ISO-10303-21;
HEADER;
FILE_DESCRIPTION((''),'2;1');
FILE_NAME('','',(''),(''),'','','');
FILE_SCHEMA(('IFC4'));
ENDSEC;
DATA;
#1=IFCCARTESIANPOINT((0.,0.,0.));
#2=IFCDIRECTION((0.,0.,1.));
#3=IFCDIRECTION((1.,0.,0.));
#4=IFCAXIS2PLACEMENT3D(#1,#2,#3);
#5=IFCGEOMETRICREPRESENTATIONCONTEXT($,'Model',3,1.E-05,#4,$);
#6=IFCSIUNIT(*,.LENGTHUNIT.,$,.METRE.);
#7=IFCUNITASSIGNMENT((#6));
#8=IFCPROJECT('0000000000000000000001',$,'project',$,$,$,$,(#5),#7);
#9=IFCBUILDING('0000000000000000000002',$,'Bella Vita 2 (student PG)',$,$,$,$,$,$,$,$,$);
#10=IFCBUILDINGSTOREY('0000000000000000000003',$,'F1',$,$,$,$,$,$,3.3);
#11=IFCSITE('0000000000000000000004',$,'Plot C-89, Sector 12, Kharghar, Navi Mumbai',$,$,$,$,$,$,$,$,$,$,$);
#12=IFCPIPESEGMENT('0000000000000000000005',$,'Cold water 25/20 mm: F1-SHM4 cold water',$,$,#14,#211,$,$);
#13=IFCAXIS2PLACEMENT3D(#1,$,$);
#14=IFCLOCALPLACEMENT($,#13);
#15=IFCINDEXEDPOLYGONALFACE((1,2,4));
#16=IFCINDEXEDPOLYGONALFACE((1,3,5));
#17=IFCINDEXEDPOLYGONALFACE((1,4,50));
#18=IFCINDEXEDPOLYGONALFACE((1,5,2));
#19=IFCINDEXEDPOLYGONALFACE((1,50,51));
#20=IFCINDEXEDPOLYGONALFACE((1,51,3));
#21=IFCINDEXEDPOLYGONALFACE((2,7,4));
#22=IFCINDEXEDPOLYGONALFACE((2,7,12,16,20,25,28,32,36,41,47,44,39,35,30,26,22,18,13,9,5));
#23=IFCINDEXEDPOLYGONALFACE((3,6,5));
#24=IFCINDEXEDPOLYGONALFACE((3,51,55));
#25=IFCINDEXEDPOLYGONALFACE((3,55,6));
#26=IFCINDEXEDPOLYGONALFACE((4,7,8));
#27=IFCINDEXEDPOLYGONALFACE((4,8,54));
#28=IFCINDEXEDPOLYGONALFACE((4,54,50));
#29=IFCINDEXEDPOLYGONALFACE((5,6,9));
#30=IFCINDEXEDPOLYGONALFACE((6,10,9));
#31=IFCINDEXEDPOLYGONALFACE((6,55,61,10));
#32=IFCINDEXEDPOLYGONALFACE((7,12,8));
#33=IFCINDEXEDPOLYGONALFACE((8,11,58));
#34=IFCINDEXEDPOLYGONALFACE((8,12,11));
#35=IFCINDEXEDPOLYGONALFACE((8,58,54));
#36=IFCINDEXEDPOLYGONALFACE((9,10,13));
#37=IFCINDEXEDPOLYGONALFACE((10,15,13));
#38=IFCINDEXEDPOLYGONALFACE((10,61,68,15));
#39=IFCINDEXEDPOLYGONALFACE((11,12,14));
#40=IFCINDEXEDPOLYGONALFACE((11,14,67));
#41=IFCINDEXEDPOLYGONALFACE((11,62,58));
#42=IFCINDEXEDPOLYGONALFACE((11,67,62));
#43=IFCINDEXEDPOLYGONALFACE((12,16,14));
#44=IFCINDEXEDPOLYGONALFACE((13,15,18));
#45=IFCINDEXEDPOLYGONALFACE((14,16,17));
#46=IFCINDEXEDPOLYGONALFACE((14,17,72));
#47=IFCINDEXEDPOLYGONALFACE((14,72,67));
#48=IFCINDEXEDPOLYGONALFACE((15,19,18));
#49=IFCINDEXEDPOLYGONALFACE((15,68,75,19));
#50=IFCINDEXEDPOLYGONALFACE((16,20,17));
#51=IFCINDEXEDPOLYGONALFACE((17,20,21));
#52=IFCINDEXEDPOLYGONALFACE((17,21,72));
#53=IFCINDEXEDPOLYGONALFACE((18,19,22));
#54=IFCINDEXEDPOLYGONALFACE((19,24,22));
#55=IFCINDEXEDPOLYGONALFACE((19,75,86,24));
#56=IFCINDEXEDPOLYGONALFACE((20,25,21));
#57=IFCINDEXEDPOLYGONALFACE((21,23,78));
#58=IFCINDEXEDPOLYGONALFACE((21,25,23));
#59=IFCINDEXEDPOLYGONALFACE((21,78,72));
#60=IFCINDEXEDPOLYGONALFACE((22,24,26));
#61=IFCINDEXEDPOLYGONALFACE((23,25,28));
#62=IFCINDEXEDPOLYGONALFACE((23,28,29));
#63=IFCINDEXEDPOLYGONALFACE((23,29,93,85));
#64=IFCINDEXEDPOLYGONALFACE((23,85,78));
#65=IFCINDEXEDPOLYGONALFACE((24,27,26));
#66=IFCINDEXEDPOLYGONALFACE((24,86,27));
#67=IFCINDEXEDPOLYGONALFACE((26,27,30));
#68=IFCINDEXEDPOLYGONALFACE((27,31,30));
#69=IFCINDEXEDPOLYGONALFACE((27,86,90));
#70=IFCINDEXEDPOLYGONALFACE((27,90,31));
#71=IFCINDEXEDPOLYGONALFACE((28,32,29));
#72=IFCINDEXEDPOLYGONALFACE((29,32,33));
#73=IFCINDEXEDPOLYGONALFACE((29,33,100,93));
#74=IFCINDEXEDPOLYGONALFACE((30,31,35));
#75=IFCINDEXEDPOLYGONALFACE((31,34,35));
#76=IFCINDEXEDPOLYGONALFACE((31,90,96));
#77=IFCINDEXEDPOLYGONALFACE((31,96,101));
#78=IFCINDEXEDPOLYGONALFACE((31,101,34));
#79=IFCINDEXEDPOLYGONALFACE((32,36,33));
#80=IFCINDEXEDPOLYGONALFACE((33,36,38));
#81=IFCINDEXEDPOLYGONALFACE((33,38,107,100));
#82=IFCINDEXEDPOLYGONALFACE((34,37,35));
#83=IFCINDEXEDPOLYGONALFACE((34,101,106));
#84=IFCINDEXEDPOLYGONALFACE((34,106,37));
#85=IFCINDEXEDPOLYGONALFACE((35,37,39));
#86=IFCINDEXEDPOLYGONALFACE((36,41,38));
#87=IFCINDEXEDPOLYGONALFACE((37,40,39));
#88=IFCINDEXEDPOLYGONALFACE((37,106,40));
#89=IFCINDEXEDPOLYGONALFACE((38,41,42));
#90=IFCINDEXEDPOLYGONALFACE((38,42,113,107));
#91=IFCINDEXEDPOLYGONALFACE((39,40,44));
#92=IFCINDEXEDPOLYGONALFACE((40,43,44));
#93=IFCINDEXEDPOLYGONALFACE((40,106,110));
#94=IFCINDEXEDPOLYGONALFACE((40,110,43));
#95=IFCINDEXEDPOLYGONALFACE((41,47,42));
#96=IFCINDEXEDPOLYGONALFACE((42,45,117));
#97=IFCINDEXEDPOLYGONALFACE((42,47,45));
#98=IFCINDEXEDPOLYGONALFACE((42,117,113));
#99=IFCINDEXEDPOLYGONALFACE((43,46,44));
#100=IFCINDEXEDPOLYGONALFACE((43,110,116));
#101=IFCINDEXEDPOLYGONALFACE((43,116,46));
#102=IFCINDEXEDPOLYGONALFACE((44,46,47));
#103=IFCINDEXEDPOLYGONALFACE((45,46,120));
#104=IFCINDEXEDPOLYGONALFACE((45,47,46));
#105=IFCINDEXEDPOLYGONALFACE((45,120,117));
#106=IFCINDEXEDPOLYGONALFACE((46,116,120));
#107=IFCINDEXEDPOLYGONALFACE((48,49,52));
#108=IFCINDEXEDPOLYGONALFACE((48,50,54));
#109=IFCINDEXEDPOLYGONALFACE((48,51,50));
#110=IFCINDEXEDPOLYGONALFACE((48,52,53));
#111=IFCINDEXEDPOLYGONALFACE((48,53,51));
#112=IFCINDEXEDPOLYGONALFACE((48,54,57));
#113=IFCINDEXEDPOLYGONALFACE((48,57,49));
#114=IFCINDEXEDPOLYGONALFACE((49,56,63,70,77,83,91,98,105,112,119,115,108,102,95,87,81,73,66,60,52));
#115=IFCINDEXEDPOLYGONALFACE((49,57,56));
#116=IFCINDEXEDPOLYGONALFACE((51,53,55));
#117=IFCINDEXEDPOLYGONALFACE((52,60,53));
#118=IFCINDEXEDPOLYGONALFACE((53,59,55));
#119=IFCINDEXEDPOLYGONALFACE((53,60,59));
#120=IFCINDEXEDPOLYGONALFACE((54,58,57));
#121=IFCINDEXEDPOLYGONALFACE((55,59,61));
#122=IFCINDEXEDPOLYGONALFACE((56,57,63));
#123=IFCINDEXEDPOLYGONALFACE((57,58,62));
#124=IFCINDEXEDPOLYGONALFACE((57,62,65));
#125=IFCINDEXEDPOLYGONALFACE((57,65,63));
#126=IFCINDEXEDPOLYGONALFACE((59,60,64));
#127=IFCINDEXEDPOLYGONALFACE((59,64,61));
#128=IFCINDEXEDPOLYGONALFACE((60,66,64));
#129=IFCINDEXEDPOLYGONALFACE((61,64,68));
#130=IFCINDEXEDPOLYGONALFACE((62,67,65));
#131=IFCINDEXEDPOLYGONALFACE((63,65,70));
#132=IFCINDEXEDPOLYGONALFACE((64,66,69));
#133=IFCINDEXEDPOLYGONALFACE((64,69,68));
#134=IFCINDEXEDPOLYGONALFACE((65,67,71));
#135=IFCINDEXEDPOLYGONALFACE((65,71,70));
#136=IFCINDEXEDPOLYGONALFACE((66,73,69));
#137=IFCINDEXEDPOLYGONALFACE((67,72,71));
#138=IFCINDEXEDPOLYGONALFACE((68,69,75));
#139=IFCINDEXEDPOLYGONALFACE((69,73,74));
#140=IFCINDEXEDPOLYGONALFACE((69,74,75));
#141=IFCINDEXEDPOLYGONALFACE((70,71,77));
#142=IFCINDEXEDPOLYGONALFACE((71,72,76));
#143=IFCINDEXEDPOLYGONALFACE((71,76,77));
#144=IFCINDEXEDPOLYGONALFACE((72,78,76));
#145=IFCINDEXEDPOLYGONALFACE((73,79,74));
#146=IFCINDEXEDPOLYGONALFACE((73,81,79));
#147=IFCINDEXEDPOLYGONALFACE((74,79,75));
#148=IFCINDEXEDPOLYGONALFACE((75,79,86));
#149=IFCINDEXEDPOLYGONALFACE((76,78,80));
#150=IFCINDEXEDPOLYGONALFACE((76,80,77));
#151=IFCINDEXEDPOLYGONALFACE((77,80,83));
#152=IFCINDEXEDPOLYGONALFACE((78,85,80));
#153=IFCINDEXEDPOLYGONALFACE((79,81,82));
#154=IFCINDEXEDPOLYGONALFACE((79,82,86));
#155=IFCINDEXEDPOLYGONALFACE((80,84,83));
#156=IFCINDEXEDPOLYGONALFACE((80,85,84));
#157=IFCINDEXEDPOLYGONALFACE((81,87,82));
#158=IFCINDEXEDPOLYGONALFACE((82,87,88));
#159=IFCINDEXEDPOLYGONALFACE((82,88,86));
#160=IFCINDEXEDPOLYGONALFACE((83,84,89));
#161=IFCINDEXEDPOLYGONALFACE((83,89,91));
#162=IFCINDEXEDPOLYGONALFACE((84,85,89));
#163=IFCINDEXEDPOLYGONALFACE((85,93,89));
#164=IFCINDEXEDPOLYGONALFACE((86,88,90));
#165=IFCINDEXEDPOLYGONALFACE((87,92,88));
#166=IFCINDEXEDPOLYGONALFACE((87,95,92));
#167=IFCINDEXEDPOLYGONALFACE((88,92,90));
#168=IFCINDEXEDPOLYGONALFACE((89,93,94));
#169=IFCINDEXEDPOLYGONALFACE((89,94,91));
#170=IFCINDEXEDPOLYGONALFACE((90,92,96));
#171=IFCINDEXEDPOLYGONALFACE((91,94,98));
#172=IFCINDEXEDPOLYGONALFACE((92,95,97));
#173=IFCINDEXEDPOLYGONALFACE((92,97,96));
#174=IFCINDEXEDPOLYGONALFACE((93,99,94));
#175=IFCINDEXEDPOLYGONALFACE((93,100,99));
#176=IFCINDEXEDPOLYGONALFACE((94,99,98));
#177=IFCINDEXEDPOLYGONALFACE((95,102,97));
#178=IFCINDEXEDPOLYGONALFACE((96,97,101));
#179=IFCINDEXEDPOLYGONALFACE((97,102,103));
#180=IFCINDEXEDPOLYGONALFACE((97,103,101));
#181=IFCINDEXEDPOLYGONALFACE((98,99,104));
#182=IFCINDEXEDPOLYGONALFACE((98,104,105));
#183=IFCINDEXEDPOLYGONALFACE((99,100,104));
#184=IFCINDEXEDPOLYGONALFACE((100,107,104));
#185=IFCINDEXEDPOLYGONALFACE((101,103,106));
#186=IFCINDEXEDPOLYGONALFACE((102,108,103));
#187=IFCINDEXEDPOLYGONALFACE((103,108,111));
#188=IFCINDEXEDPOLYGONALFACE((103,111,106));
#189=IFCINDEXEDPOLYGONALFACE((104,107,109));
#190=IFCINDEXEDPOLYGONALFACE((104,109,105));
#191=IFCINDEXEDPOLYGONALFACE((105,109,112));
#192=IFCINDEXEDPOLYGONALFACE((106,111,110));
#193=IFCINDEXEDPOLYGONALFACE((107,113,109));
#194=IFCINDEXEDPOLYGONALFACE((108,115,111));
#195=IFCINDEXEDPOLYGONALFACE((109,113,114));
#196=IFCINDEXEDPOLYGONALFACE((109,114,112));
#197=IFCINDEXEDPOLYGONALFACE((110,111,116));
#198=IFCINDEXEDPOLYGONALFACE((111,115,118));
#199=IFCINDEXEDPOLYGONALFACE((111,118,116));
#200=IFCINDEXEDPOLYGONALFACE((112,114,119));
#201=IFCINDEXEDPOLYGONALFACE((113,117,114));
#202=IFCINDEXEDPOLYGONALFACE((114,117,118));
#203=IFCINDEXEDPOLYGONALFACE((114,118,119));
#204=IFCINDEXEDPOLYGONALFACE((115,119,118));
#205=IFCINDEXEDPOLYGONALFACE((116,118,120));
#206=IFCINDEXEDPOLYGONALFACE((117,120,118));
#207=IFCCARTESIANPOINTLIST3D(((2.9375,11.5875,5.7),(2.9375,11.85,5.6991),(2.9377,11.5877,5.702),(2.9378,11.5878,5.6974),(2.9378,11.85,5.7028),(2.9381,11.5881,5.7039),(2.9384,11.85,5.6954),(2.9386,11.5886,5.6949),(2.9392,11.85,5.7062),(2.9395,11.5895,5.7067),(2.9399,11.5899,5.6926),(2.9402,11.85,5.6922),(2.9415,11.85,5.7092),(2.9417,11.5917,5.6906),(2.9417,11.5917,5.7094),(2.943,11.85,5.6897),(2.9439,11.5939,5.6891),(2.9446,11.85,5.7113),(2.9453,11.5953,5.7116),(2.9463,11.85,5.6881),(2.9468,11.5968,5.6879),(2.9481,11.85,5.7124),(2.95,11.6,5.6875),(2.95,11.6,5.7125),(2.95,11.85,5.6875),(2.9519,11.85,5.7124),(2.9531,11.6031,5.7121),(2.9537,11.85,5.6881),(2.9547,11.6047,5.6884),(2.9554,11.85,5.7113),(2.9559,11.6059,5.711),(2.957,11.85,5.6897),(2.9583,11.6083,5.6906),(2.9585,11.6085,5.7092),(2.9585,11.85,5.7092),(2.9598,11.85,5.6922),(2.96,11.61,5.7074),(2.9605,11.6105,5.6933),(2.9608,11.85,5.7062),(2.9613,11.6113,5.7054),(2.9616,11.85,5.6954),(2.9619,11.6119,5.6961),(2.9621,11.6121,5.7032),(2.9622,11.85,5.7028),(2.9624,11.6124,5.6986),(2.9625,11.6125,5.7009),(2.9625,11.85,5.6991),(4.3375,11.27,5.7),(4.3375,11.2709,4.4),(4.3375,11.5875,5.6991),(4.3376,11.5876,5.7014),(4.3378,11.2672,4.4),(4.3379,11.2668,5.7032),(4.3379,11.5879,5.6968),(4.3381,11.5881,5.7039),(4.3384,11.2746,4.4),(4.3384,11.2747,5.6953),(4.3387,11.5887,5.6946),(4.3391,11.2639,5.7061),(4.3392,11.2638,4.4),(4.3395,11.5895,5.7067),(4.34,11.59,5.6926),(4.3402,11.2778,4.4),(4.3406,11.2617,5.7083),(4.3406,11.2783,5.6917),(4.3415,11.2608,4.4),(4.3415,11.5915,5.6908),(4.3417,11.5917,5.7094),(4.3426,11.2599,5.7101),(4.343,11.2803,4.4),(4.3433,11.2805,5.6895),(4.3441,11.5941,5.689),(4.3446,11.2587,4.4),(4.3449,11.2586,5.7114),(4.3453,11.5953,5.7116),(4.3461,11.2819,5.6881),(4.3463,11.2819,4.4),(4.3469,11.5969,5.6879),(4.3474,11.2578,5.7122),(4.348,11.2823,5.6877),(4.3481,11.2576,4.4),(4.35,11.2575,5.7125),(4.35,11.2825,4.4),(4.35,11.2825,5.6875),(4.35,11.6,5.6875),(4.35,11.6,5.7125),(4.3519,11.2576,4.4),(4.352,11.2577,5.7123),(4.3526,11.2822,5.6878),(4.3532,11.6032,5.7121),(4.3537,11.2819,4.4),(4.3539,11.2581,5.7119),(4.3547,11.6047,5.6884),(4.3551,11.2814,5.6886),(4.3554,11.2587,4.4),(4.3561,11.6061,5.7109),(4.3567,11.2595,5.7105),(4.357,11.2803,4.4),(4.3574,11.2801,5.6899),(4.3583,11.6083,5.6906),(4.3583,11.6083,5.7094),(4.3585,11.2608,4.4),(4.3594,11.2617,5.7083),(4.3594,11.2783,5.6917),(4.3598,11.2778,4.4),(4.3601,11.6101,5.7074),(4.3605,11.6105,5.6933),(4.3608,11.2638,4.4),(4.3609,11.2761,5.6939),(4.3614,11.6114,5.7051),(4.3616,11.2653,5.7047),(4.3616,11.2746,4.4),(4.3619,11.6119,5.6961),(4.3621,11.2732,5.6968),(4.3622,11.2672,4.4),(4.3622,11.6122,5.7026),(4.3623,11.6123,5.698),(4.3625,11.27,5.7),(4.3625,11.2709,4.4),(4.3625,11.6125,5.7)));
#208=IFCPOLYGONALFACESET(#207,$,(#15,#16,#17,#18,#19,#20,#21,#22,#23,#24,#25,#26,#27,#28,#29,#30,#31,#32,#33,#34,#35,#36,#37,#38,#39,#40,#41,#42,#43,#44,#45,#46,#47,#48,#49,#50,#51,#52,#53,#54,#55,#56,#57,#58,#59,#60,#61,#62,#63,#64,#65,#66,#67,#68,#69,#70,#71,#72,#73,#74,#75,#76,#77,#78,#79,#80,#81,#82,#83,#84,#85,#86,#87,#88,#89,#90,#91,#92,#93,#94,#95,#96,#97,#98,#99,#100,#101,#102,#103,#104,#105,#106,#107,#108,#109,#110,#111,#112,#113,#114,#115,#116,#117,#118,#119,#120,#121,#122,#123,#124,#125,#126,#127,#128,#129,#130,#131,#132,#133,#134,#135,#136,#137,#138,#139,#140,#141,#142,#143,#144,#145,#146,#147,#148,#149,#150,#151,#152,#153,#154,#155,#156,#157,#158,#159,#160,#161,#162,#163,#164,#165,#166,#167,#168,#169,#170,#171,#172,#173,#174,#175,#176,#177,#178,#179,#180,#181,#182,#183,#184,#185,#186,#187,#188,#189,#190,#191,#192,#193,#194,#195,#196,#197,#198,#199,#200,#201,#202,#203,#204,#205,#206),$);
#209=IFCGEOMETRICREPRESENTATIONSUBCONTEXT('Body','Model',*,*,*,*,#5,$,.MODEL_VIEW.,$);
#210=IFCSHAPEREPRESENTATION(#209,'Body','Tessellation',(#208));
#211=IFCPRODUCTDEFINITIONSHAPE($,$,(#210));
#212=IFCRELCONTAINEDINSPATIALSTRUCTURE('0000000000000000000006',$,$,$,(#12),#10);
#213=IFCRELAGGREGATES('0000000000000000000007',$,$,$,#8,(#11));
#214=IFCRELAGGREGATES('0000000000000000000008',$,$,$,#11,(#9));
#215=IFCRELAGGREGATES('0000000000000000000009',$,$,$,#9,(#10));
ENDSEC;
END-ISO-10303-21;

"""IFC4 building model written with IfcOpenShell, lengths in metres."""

from ifc_helpers import new_model, entity, si_unit, origin, origin_with_axes, place, context, subcontext, project, spatial, element, save


model = new_model("IFC4")

# Units and contexts
model_context = context("Model", 3, precision=1e-05, world=origin_with_axes())
body_context = subcontext(model_context, "Body", "Model", "MODEL_VIEW")
ifc_project = project(units=[si_unit("LENGTHUNIT", "METRE")], contexts=[model_context])

# Site, building, storey
site = spatial("IfcSite", under=ifc_project, Name="Plot C-89, Sector 12, Kharghar, Navi Mumbai")
building = spatial("IfcBuilding", under=site, Name="Bella Vita 2 (student PG)")
storey = spatial("IfcBuildingStorey", under=building, Name="F1", Elevation=3.3)

# Pipe segment
pipe_segment_1_placement = place(None, origin())
element("IfcPipeSegment", 1, at=pipe_segment_1_placement, inside=storey, Name="Cold water 25/20 mm: F1-SHM4 cold water", context=body_context, shape_type="AdvancedSweptSolid", body=[
    entity("IfcSweptDiskSolid", entity("IfcPolyline", [entity("IfcCartesianPoint", [2.95, 11.85, 5.7]), entity("IfcCartesianPoint", [2.95, 11.6, 5.7]), entity("IfcCartesianPoint", [4.35, 11.6, 5.7]), entity("IfcCartesianPoint", [4.35, 11.27, 5.7]), entity("IfcCartesianPoint", [4.35, 11.27, 4.4])]), 0.0125),
])

save(model, "model.ifc")
